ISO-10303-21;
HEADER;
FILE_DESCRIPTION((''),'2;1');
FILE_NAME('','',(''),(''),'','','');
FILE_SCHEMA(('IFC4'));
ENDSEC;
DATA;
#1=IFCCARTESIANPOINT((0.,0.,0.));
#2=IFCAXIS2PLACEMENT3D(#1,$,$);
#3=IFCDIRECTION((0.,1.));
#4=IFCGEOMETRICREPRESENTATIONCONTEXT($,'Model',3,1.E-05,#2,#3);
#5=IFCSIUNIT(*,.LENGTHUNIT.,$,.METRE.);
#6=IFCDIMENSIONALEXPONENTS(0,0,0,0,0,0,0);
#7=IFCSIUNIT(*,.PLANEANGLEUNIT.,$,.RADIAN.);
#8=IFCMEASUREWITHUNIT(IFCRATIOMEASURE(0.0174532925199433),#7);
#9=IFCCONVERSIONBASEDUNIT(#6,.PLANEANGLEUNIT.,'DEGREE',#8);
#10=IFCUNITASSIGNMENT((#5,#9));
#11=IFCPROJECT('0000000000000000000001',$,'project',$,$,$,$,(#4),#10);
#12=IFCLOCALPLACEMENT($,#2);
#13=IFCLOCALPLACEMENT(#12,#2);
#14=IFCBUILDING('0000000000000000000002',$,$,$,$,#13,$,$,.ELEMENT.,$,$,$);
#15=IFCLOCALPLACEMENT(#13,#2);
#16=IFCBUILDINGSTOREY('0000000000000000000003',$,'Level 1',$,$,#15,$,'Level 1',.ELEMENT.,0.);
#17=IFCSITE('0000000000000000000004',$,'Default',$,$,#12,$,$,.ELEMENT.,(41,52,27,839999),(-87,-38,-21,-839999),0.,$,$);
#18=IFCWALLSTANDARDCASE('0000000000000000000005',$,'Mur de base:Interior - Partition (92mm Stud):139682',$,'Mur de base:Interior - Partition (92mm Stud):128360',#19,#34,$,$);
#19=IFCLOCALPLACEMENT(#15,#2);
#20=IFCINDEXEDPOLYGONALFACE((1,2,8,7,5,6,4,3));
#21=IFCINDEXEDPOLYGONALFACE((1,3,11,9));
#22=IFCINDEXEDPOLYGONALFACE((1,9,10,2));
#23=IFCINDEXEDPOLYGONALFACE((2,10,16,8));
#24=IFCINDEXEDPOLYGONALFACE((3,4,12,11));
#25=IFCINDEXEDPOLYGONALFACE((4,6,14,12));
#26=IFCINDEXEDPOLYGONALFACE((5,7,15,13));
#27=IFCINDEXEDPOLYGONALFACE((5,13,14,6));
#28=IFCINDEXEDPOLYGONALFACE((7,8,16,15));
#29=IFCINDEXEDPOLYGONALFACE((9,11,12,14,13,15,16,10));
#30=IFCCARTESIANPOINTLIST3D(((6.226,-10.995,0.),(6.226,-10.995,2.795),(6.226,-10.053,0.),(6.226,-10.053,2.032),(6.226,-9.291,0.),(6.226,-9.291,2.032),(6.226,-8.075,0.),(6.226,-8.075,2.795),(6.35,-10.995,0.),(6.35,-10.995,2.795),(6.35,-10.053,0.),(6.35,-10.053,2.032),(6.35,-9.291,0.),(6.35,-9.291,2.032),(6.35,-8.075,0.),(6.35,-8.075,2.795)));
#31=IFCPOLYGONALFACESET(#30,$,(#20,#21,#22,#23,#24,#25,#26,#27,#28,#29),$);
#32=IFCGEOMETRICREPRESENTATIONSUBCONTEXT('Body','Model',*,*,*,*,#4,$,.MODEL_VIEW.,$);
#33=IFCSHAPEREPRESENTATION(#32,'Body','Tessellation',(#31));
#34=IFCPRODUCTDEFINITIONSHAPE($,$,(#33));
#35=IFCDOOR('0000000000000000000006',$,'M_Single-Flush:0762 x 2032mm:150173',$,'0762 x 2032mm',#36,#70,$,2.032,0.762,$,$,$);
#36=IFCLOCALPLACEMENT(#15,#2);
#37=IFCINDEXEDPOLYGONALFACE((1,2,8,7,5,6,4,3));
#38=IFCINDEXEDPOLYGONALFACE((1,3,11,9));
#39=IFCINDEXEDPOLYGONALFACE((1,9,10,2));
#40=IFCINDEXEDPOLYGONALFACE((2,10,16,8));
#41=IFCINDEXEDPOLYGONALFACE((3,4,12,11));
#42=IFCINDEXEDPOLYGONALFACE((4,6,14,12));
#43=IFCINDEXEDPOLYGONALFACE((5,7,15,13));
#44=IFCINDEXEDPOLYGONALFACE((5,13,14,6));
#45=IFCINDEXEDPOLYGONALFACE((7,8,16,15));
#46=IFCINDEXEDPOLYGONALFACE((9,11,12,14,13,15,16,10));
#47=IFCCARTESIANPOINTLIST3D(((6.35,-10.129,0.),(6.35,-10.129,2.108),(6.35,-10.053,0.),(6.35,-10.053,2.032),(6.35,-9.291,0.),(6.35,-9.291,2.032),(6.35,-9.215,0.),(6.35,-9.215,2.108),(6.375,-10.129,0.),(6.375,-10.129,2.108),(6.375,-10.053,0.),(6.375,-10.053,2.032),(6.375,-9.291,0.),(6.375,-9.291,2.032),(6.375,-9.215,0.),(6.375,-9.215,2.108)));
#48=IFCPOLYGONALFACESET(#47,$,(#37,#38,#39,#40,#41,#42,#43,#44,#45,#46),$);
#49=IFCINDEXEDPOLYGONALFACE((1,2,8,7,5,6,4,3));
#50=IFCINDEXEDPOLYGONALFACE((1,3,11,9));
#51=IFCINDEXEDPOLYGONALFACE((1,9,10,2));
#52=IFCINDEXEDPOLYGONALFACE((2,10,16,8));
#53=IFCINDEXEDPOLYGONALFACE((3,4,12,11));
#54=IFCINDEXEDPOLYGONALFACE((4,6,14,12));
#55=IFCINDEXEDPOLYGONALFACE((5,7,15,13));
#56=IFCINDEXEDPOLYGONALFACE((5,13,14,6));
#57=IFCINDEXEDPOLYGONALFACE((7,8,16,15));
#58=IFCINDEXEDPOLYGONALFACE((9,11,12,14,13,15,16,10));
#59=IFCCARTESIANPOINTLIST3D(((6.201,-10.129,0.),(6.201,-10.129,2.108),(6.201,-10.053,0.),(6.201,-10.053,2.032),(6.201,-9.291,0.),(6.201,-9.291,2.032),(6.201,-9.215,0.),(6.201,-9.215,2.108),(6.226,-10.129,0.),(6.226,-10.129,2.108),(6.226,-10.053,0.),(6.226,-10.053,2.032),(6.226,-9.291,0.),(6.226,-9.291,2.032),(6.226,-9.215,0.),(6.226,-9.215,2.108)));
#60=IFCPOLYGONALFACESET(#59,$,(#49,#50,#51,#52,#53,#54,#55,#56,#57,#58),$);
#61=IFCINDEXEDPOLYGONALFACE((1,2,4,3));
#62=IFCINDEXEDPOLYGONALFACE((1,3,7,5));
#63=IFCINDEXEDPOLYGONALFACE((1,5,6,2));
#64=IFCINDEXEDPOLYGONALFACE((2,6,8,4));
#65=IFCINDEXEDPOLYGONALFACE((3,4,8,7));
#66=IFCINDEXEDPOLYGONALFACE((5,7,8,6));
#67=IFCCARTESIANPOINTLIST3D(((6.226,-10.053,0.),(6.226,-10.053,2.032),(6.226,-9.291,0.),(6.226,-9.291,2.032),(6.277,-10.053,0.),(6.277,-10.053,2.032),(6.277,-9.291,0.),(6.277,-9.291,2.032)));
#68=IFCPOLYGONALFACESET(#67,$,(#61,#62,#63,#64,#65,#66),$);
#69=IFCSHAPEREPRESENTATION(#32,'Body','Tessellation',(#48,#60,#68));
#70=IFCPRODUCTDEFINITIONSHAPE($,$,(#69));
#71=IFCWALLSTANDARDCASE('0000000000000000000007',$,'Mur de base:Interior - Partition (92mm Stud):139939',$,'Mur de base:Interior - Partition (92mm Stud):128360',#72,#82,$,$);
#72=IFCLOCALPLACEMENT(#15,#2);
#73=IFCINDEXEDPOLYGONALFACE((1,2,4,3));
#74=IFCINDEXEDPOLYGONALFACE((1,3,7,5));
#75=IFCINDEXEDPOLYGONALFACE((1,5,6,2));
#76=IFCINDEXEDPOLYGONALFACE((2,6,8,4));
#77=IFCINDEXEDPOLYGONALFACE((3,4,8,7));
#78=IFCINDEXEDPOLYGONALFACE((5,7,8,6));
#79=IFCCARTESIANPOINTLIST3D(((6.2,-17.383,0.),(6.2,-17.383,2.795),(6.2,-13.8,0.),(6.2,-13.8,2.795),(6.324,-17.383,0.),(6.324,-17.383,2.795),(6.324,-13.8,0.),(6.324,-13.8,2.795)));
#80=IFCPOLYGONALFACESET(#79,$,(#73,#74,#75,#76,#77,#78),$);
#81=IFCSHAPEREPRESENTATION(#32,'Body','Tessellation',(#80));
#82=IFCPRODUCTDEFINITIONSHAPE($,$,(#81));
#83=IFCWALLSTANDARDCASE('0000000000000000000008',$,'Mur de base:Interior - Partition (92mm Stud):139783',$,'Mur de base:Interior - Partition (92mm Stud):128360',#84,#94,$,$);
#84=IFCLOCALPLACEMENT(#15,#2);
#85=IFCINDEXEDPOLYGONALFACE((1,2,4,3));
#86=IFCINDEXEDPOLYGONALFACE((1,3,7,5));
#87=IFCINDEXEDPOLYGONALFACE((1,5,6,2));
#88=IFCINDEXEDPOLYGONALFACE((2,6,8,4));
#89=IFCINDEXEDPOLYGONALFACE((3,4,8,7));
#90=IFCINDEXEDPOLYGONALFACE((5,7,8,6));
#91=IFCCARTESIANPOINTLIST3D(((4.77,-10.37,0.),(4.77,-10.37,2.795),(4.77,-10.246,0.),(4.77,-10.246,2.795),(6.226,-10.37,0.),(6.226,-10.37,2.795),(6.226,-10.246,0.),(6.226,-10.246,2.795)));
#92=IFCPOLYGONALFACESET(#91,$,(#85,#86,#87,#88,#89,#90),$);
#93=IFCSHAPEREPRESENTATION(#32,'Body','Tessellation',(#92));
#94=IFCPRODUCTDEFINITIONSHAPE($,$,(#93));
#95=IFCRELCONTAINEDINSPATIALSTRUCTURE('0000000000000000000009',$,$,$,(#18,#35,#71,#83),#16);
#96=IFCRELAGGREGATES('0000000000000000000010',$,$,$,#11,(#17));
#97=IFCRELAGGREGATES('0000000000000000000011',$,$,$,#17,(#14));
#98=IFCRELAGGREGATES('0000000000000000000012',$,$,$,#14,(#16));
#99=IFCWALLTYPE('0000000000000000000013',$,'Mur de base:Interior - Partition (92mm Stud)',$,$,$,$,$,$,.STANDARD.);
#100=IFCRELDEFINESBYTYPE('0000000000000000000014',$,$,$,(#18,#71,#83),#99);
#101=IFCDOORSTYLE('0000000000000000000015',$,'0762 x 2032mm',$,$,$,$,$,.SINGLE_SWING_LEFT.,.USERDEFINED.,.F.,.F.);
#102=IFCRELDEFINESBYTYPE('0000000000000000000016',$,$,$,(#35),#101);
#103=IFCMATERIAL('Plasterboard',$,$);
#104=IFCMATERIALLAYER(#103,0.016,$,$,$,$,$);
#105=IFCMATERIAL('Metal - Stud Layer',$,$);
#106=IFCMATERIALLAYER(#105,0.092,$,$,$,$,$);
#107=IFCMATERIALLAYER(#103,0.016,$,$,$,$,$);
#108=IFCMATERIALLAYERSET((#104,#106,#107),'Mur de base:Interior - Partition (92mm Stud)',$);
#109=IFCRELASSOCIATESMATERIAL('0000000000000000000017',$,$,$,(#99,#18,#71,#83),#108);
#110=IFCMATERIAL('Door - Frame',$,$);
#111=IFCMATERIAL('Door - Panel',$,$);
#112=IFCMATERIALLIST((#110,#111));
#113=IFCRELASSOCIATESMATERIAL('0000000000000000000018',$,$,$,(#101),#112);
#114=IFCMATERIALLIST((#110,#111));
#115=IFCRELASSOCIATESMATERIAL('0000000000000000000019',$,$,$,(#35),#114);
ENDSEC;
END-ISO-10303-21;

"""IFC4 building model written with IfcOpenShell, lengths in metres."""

from ifc_helpers import new_model, entity, si_unit, converted_unit, direction, frame, frame_2d, origin, place, context, subcontext, project, spatial, polyline, rectangle, outline, extrude, source, transform, mapped, material, material_list, layer, layer_set, layer_usage, type_object, type_shapes, element, fill, save


model = new_model("IFC4")

# Units and contexts
model_context = context("Model", 3, precision=1e-05, world=origin(), true_north=direction((0.0, 1.0)))
body_context = subcontext(model_context, "Body", "Model", "MODEL_VIEW")
ifc_project = project(units=[si_unit("LENGTHUNIT", "METRE"), converted_unit("PLANEANGLEUNIT", "DEGREE", entity("IfcRatioMeasure", 0.0174532925199433), si_unit("PLANEANGLEUNIT", "RADIAN"), dimensions=[0, 0, 0, 0, 0, 0, 0])], contexts=[model_context])

# Site, building, storey
site_placement = place(None, origin())
site = spatial("IfcSite", under=ifc_project, at=site_placement, Name="Default", CompositionType="ELEMENT", RefLatitude=(41, 52, 27, 839999), RefLongitude=(-87, -38, -21, -839999), RefElevation=0.0)
building_placement = place(site_placement, origin())
building = spatial("IfcBuilding", under=site, at=building_placement, CompositionType="ELEMENT")
storey_placement = place(building_placement, origin())
storey = spatial("IfcBuildingStorey", under=building, at=storey_placement, Name="Level 1", LongName="Level 1", CompositionType="ELEMENT", Elevation=0.0)

# Wall, opening, door
ifc_material_1 = material(Name="Plasterboard")
ifc_layer_1 = layer(ifc_material_1, 0.016)
ifc_material_2 = material(Name="Metal - Stud Layer")
ifc_layer_2 = layer(ifc_material_2, 0.092)
ifc_layer_3 = layer(ifc_material_1, 0.016)
ifc_layer_set_1 = layer_set([ifc_layer_1, ifc_layer_2, ifc_layer_3], Name="Mur de base:Interior - Partition (92mm Stud)")
ifc_layer_usage_1 = layer_usage(ifc_layer_set_1, "AXIS2", "NEGATIVE", 0.062)
wall_type_1 = type_object("IfcWallType", Name="Mur de base:Interior - Partition (92mm Stud)", PredefinedType="STANDARD", material=ifc_layer_set_1)
wall_1_placement = place(storey_placement, frame((6.288, -10.995, 0.0), z_axis=(0.0, 0.0, 1.0), x_axis=(0.0, 1.0, 0.0)))
wall_1 = element("IfcWallStandardCase", 1, at=wall_1_placement, inside=storey, type_object=wall_type_1, material=ifc_layer_usage_1, Name="Mur de base:Interior - Partition (92mm Stud):139682", ObjectType="Mur de base:Interior - Partition (92mm Stud):128360", context=body_context, shape_type="SweptSolid", body=[
    extrude(rectangle(XDim=2.92, YDim=0.124, at=frame_2d((1.46, 0.0), x_axis=(-1.0, 0.0))), origin(), (0.0, 0.0, 1.0), 2.795),
])
opening_1_placement = place(wall_1_placement, frame((0.942, -0.062, 0.0)))
opening_1 = element("IfcOpeningElement", 2, at=opening_1_placement, cuts=wall_1, ObjectType="Opening", context=body_context, shape_type="SweptSolid", body=[
    extrude(rectangle(XDim=0.762, YDim=2.032, at=frame_2d((1.016, 0.381), x_axis=(0.0, -1.0))), frame((0.0, 0.0, 0.0), z_axis=(0.0, 1.0, 0.0), x_axis=(0.0, 0.0, 1.0)), (0.0, 0.0, 1.0), 0.124),
])
ifc_material_3 = material(Name="Door - Frame")
ifc_material_4 = material(Name="Door - Panel")
ifc_material_list_1 = material_list([ifc_material_3, ifc_material_4])
ifc_material_list_2 = material_list([ifc_material_3, ifc_material_4])
door_style_1 = type_object("IfcDoorStyle", Name="0762 x 2032mm", ConstructionType="USERDEFINED", OperationType="SINGLE_SWING_LEFT", ParameterTakesPrecedence=False, Sizeable=False, material=ifc_material_list_2)
shared_shape_1 = source(origin(), body_context, "Body", "SweptSolid", [
    extrude(outline(polyline([(-1.073, -0.457), (1.035, -0.457), (1.035, -0.381), (-0.997, -0.381), (-0.997, 0.381), (1.035, 0.381), (1.035, 0.457), (-1.073, 0.457), (-1.073, -0.457)])), frame((0.381, 0.0, 1.035), z_axis=(0.0, -1.0, 0.0), x_axis=(0.0, 0.0, -1.0)), (0.0, 0.0, 1.0), 0.025),
    extrude(outline(polyline([(-0.457, -1.073), (0.457, -1.073), (0.457, 1.035), (0.381, 1.035), (0.381, -0.997), (-0.381, -0.997), (-0.381, 1.035), (-0.457, 1.035), (-0.457, -1.073)])), frame((0.381, 0.149, 1.035), z_axis=(0.0, -1.0, 0.0), x_axis=(-1.0, 0.0, 0.0)), (0.0, 0.0, 1.0), 0.025),
    extrude(rectangle(XDim=0.762, YDim=0.051, at=frame_2d((0.0, 0.0), x_axis=(1.0, 0.0))), frame((0.381, 0.0985, 0.0)), (0.0, 0.0, 1.0), 2.032),
])
type_shapes(door_style_1, [shared_shape_1])
door_1_placement = place(opening_1_placement, origin())
door_1 = element("IfcDoor", 3, at=door_1_placement, inside=storey, type_object=door_style_1, material=ifc_material_list_1, Name="M_Single-Flush:0762 x 2032mm:150173", ObjectType="0762 x 2032mm", OverallHeight=2.032, OverallWidth=0.762, context=body_context, shape_type="MappedRepresentation", body=[
    mapped(shared_shape_1, transform((0.0, 0.0, 0.0), scale=1.0)),
])
fill(opening_1, door_1)

# Walls
ifc_layer_usage_2 = layer_usage(ifc_layer_set_1, "AXIS2", "NEGATIVE", 0.062)
wall_2_placement = place(storey_placement, frame((6.262, -13.8, 0.0), z_axis=(0.0, 0.0, 1.0), x_axis=(0.0, -1.0, 0.0)))
element("IfcWallStandardCase", 4, at=wall_2_placement, inside=storey, type_object=wall_type_1, material=ifc_layer_usage_2, Name="Mur de base:Interior - Partition (92mm Stud):139939", ObjectType="Mur de base:Interior - Partition (92mm Stud):128360", context=body_context, shape_type="SweptSolid", body=[
    extrude(rectangle(XDim=3.583, YDim=0.124, at=frame_2d((1.7915, 0.0), x_axis=(-1.0, 0.0))), origin(), (0.0, 0.0, 1.0), 2.795),
])
ifc_layer_usage_3 = layer_usage(ifc_layer_set_1, "AXIS2", "NEGATIVE", 0.062)
wall_3_placement = place(storey_placement, frame((4.77, -10.308, 0.0)))
element("IfcWallStandardCase", 5, at=wall_3_placement, inside=storey, type_object=wall_type_1, material=ifc_layer_usage_3, Name="Mur de base:Interior - Partition (92mm Stud):139783", ObjectType="Mur de base:Interior - Partition (92mm Stud):128360", context=body_context, shape_type="SweptSolid", body=[
    extrude(rectangle(XDim=1.456, YDim=0.124, at=frame_2d((0.728, 0.0), x_axis=(-1.0, 0.0))), origin(), (0.0, 0.0, 1.0), 2.795),
])

save(model, "model.ifc")
